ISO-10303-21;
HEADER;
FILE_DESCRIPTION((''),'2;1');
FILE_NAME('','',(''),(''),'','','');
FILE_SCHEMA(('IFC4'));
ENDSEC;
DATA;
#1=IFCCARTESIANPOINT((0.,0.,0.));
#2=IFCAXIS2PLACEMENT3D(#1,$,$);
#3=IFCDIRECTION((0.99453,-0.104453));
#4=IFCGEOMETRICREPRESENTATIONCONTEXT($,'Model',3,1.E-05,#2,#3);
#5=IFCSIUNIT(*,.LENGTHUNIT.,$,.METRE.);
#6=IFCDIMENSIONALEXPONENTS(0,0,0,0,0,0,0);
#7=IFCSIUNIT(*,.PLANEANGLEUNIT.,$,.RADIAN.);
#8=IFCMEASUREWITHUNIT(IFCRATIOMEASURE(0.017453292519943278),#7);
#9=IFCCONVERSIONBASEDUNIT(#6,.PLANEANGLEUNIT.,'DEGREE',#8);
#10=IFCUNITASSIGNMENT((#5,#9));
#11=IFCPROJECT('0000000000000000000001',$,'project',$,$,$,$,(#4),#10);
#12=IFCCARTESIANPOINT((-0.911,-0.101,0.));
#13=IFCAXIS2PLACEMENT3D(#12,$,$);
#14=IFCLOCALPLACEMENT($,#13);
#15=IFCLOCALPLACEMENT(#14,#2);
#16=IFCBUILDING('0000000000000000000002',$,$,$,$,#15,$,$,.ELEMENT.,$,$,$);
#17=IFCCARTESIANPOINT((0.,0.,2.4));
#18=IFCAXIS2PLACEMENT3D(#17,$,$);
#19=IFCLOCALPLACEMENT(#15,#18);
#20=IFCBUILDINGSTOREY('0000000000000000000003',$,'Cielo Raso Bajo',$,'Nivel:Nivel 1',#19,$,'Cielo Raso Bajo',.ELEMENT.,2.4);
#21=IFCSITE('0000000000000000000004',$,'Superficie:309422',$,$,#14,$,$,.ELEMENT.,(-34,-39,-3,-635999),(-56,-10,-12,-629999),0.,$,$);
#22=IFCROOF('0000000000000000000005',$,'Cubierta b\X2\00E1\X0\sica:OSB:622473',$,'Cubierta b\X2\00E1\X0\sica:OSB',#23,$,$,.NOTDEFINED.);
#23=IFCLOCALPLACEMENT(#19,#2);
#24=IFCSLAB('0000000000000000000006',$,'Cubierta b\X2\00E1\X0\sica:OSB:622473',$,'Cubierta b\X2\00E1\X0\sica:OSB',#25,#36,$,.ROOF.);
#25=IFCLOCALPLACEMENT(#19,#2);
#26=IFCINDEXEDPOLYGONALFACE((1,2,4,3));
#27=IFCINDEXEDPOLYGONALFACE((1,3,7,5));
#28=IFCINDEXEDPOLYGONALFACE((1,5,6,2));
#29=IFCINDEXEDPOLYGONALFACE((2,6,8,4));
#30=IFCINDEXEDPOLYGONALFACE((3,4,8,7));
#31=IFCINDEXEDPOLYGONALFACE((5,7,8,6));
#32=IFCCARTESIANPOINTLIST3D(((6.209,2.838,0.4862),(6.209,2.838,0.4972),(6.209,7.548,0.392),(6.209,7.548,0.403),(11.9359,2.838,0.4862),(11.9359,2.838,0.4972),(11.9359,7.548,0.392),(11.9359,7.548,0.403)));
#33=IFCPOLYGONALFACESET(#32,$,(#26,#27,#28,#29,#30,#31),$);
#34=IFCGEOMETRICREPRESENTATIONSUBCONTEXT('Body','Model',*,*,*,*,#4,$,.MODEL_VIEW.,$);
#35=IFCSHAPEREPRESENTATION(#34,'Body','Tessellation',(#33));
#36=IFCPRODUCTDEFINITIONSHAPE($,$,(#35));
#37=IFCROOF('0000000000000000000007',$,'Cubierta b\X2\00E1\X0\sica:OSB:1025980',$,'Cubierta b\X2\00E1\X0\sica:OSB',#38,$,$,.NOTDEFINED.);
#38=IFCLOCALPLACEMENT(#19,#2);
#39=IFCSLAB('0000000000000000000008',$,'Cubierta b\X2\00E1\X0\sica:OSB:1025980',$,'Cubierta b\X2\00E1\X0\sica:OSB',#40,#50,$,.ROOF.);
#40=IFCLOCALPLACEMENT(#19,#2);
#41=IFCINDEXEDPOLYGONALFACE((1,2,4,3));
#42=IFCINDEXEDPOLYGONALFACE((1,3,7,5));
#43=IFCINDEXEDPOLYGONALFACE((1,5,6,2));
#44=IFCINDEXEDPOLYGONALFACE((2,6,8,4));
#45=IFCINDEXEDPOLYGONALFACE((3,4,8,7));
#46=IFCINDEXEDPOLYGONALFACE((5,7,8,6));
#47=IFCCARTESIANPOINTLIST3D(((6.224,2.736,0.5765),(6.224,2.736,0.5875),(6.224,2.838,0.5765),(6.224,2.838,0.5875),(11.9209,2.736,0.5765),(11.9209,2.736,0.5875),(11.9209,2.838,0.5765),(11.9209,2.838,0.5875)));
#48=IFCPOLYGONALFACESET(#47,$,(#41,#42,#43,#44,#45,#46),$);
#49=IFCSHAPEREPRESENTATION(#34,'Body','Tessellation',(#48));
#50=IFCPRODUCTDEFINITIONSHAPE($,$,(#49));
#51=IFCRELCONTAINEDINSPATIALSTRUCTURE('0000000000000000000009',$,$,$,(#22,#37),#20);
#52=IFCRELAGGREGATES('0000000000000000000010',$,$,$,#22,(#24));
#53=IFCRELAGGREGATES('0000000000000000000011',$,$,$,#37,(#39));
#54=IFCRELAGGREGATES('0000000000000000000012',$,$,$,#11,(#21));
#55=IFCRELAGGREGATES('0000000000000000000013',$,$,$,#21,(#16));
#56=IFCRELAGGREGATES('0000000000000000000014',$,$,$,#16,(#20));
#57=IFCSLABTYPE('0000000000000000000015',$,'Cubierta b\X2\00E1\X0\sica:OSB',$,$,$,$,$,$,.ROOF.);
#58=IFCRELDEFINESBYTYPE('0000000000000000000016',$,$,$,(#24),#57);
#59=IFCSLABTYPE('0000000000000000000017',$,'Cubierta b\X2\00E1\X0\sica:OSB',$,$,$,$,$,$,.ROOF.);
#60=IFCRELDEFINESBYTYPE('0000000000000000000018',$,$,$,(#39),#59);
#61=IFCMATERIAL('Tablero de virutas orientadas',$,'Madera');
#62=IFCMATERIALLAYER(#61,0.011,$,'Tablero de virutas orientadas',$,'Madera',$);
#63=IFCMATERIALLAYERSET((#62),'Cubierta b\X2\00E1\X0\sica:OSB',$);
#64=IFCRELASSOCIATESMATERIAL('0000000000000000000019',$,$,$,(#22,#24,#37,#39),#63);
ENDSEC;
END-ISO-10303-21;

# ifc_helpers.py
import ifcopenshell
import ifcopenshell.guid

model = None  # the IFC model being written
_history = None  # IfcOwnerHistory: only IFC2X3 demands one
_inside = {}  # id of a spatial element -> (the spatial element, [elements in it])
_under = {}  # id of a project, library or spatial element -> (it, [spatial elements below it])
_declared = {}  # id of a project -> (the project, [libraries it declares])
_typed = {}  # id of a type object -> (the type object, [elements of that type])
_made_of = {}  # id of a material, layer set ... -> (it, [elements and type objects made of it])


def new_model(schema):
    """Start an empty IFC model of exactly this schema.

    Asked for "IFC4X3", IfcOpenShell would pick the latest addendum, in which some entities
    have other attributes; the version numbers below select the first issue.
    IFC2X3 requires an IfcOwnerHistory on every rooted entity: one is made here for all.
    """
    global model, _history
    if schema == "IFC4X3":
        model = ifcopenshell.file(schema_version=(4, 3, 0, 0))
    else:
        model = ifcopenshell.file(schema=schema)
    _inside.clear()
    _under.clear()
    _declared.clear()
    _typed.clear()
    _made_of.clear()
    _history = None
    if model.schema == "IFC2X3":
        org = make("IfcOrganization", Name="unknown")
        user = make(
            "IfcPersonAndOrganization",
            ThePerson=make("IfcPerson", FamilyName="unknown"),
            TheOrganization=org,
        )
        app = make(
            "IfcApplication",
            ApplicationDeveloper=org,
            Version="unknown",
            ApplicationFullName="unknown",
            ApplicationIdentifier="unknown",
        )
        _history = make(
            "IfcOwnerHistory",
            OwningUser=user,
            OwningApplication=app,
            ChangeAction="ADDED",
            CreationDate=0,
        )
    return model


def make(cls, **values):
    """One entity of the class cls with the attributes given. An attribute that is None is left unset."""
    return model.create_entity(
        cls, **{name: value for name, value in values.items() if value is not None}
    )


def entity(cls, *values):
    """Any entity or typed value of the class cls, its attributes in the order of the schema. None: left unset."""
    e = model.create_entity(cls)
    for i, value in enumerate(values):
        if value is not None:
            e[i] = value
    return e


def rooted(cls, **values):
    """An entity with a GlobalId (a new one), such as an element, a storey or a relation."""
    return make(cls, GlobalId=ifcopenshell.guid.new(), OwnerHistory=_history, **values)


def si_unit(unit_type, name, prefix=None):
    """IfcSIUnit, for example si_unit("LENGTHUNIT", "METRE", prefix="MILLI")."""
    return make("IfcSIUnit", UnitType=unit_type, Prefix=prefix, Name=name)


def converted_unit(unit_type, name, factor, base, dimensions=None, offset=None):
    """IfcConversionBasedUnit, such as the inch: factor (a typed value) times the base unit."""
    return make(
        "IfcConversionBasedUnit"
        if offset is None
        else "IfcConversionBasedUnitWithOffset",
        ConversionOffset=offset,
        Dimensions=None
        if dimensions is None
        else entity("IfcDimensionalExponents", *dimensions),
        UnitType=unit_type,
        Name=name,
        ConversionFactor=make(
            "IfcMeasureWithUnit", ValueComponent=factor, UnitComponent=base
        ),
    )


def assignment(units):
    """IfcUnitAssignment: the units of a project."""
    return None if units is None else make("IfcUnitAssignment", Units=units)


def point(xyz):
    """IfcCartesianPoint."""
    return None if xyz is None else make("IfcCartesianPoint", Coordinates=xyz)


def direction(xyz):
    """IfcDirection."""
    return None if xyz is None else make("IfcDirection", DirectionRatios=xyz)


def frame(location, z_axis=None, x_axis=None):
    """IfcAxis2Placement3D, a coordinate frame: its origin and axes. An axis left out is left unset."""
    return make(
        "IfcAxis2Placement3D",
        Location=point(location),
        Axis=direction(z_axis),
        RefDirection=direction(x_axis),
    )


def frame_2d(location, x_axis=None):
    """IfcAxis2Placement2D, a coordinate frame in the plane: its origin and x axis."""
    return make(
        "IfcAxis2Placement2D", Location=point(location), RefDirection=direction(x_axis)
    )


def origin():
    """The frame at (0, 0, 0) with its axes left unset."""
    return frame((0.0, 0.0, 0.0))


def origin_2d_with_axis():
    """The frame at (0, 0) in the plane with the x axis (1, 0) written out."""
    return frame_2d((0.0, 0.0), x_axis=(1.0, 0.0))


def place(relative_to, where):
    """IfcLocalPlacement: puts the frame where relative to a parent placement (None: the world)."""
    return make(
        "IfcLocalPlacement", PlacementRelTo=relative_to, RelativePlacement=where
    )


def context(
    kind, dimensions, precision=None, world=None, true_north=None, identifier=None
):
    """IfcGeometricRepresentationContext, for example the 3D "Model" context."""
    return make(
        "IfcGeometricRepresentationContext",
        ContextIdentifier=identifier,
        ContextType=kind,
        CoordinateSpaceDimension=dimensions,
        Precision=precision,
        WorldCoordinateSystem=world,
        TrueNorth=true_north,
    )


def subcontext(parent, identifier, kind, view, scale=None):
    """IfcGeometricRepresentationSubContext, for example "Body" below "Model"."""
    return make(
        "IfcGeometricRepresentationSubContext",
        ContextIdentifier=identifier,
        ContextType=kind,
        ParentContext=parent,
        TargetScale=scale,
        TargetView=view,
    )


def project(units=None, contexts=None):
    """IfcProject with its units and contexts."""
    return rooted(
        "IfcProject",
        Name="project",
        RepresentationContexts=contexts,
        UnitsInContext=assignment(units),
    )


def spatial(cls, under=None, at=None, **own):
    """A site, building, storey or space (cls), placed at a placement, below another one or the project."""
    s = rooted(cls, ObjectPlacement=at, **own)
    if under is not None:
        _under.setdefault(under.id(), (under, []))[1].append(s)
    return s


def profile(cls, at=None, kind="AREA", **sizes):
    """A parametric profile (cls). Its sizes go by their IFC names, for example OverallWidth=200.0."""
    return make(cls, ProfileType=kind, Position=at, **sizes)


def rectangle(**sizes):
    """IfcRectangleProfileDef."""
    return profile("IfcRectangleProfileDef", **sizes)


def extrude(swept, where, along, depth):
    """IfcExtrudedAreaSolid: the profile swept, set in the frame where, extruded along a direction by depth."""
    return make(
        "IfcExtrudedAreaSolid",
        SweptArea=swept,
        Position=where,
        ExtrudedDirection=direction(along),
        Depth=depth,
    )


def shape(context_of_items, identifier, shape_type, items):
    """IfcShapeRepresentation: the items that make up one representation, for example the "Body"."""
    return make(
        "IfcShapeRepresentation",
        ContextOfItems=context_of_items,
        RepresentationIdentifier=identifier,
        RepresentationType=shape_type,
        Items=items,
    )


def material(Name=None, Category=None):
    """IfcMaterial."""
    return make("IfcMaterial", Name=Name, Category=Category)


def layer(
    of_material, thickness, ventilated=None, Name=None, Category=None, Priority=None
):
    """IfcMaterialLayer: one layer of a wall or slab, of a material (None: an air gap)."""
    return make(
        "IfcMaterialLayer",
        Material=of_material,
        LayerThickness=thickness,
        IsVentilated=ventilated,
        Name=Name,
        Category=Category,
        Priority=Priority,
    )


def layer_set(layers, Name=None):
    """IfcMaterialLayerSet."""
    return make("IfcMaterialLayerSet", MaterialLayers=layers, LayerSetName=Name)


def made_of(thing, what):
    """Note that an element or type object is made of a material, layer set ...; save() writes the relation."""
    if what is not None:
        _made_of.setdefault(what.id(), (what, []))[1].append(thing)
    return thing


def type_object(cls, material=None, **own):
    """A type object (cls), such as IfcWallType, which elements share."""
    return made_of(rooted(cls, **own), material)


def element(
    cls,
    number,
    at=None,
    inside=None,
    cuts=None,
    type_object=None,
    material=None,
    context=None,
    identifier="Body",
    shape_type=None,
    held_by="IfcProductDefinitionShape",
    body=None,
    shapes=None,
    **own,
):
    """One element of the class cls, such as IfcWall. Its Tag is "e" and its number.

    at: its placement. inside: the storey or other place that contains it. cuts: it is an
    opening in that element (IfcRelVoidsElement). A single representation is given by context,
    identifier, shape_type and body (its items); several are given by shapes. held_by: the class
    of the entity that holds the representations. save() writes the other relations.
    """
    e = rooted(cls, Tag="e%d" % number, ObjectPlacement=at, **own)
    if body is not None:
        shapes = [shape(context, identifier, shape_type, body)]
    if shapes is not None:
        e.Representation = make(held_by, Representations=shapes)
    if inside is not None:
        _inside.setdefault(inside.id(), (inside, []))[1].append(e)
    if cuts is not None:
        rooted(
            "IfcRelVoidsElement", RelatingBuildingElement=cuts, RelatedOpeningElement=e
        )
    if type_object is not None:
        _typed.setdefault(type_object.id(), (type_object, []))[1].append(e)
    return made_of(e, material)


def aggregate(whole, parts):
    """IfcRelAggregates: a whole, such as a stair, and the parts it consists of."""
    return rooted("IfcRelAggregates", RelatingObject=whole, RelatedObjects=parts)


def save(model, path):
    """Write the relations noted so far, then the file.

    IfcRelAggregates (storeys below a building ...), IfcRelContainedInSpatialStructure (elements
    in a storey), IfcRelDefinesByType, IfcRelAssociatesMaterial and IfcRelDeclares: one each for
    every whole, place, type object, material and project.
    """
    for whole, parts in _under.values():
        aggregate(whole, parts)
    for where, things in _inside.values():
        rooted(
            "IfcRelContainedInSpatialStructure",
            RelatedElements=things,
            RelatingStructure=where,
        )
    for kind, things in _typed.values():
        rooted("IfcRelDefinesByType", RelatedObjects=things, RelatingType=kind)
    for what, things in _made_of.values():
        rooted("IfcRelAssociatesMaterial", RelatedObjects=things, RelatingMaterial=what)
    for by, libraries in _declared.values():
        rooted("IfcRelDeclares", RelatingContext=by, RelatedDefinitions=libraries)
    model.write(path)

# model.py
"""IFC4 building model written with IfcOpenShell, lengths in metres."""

from ifc_helpers import new_model, entity, si_unit, converted_unit, direction, frame, frame_2d, origin, origin_2d_with_axis, place, context, subcontext, project, spatial, rectangle, extrude, material, layer, layer_set, type_object, element, aggregate, save


model = new_model("IFC4")

# Units and contexts
model_context = context("Model", 3, precision=1e-05, world=origin(), true_north=direction((0.99453, -0.104453)))
body_context = subcontext(model_context, "Body", "Model", "MODEL_VIEW")
ifc_project = project(units=[si_unit("LENGTHUNIT", "METRE"), converted_unit("PLANEANGLEUNIT", "DEGREE", entity("IfcRatioMeasure", 0.017453292519943278), si_unit("PLANEANGLEUNIT", "RADIAN"), dimensions=[0, 0, 0, 0, 0, 0, 0])], contexts=[model_context])

# Site, building, storey
site_placement = place(None, frame((-0.911, -0.101, 0.0)))
site = spatial("IfcSite", under=ifc_project, at=site_placement, Name="Superficie:309422", CompositionType="ELEMENT", RefLatitude=(-34, -39, -3, -635999), RefLongitude=(-56, -10, -12, -629999), RefElevation=0.0)
building_placement = place(site_placement, origin())
building = spatial("IfcBuilding", under=site, at=building_placement, CompositionType="ELEMENT")
storey_placement = place(building_placement, frame((0.0, 0.0, 2.4)))
storey = spatial("IfcBuildingStorey", under=building, at=storey_placement, Name="Cielo Raso Bajo", ObjectType="Nivel:Nivel 1", LongName="Cielo Raso Bajo", CompositionType="ELEMENT", Elevation=2.4)

# Roofs, slabs
ifc_material_1 = material(Name="Tablero de virutas orientadas", Category="Madera")
ifc_layer_1 = layer(ifc_material_1, 0.011, Name="Tablero de virutas orientadas", Category="Madera")
ifc_layer_set_1 = layer_set([ifc_layer_1], Name="Cubierta básica:OSB")
roof_1_placement = place(storey_placement, frame((6.209, 2.838, 0.392)))
roof_1 = element("IfcRoof", 1, at=roof_1_placement, inside=storey, material=ifc_layer_set_1, Name="Cubierta básica:OSB:622473", ObjectType="Cubierta básica:OSB", PredefinedType="NOTDEFINED")
slab_type_1 = type_object("IfcSlabType", Name="Cubierta básica:OSB", PredefinedType="ROOF")
slab_1_placement = place(roof_1_placement, origin())
slab_1 = element("IfcSlab", 2, at=slab_1_placement, type_object=slab_type_1, material=ifc_layer_set_1, Name="Cubierta básica:OSB:622473", ObjectType="Cubierta básica:OSB", PredefinedType="ROOF", context=body_context, shape_type="SweptSolid", body=[
    extrude(rectangle(XDim=5.7269, YDim=4.7109, at=frame_2d((0.0, 0.0), x_axis=(1.0, 0.0))), frame((2.8635, 2.355, 0.0471), z_axis=(0.0, 0.019983, 0.9998), x_axis=(1.0, 0.0, 0.0)), (0.0, -0.019983, 0.9998), 0.011),
])
aggregate(roof_1, [slab_1])
roof_2_placement = place(storey_placement, frame((6.224, 2.736, 0.5765)))
roof_2 = element("IfcRoof", 3, at=roof_2_placement, inside=storey, material=ifc_layer_set_1, Name="Cubierta básica:OSB:1025980", ObjectType="Cubierta básica:OSB", PredefinedType="NOTDEFINED")
slab_type_2 = type_object("IfcSlabType", Name="Cubierta básica:OSB", PredefinedType="ROOF")
slab_2_placement = place(roof_2_placement, origin())
slab_2 = element("IfcSlab", 4, at=slab_2_placement, type_object=slab_type_2, material=ifc_layer_set_1, Name="Cubierta básica:OSB:1025980", ObjectType="Cubierta básica:OSB", PredefinedType="ROOF", context=body_context, shape_type="SweptSolid", body=[
    extrude(rectangle(XDim=5.6969, YDim=0.102, at=origin_2d_with_axis()), frame((2.8485, 0.051, 0.0)), (0.0, 0.0, 1.0), 0.011),
])
aggregate(roof_2, [slab_2])

save(model, "model.ifc")
